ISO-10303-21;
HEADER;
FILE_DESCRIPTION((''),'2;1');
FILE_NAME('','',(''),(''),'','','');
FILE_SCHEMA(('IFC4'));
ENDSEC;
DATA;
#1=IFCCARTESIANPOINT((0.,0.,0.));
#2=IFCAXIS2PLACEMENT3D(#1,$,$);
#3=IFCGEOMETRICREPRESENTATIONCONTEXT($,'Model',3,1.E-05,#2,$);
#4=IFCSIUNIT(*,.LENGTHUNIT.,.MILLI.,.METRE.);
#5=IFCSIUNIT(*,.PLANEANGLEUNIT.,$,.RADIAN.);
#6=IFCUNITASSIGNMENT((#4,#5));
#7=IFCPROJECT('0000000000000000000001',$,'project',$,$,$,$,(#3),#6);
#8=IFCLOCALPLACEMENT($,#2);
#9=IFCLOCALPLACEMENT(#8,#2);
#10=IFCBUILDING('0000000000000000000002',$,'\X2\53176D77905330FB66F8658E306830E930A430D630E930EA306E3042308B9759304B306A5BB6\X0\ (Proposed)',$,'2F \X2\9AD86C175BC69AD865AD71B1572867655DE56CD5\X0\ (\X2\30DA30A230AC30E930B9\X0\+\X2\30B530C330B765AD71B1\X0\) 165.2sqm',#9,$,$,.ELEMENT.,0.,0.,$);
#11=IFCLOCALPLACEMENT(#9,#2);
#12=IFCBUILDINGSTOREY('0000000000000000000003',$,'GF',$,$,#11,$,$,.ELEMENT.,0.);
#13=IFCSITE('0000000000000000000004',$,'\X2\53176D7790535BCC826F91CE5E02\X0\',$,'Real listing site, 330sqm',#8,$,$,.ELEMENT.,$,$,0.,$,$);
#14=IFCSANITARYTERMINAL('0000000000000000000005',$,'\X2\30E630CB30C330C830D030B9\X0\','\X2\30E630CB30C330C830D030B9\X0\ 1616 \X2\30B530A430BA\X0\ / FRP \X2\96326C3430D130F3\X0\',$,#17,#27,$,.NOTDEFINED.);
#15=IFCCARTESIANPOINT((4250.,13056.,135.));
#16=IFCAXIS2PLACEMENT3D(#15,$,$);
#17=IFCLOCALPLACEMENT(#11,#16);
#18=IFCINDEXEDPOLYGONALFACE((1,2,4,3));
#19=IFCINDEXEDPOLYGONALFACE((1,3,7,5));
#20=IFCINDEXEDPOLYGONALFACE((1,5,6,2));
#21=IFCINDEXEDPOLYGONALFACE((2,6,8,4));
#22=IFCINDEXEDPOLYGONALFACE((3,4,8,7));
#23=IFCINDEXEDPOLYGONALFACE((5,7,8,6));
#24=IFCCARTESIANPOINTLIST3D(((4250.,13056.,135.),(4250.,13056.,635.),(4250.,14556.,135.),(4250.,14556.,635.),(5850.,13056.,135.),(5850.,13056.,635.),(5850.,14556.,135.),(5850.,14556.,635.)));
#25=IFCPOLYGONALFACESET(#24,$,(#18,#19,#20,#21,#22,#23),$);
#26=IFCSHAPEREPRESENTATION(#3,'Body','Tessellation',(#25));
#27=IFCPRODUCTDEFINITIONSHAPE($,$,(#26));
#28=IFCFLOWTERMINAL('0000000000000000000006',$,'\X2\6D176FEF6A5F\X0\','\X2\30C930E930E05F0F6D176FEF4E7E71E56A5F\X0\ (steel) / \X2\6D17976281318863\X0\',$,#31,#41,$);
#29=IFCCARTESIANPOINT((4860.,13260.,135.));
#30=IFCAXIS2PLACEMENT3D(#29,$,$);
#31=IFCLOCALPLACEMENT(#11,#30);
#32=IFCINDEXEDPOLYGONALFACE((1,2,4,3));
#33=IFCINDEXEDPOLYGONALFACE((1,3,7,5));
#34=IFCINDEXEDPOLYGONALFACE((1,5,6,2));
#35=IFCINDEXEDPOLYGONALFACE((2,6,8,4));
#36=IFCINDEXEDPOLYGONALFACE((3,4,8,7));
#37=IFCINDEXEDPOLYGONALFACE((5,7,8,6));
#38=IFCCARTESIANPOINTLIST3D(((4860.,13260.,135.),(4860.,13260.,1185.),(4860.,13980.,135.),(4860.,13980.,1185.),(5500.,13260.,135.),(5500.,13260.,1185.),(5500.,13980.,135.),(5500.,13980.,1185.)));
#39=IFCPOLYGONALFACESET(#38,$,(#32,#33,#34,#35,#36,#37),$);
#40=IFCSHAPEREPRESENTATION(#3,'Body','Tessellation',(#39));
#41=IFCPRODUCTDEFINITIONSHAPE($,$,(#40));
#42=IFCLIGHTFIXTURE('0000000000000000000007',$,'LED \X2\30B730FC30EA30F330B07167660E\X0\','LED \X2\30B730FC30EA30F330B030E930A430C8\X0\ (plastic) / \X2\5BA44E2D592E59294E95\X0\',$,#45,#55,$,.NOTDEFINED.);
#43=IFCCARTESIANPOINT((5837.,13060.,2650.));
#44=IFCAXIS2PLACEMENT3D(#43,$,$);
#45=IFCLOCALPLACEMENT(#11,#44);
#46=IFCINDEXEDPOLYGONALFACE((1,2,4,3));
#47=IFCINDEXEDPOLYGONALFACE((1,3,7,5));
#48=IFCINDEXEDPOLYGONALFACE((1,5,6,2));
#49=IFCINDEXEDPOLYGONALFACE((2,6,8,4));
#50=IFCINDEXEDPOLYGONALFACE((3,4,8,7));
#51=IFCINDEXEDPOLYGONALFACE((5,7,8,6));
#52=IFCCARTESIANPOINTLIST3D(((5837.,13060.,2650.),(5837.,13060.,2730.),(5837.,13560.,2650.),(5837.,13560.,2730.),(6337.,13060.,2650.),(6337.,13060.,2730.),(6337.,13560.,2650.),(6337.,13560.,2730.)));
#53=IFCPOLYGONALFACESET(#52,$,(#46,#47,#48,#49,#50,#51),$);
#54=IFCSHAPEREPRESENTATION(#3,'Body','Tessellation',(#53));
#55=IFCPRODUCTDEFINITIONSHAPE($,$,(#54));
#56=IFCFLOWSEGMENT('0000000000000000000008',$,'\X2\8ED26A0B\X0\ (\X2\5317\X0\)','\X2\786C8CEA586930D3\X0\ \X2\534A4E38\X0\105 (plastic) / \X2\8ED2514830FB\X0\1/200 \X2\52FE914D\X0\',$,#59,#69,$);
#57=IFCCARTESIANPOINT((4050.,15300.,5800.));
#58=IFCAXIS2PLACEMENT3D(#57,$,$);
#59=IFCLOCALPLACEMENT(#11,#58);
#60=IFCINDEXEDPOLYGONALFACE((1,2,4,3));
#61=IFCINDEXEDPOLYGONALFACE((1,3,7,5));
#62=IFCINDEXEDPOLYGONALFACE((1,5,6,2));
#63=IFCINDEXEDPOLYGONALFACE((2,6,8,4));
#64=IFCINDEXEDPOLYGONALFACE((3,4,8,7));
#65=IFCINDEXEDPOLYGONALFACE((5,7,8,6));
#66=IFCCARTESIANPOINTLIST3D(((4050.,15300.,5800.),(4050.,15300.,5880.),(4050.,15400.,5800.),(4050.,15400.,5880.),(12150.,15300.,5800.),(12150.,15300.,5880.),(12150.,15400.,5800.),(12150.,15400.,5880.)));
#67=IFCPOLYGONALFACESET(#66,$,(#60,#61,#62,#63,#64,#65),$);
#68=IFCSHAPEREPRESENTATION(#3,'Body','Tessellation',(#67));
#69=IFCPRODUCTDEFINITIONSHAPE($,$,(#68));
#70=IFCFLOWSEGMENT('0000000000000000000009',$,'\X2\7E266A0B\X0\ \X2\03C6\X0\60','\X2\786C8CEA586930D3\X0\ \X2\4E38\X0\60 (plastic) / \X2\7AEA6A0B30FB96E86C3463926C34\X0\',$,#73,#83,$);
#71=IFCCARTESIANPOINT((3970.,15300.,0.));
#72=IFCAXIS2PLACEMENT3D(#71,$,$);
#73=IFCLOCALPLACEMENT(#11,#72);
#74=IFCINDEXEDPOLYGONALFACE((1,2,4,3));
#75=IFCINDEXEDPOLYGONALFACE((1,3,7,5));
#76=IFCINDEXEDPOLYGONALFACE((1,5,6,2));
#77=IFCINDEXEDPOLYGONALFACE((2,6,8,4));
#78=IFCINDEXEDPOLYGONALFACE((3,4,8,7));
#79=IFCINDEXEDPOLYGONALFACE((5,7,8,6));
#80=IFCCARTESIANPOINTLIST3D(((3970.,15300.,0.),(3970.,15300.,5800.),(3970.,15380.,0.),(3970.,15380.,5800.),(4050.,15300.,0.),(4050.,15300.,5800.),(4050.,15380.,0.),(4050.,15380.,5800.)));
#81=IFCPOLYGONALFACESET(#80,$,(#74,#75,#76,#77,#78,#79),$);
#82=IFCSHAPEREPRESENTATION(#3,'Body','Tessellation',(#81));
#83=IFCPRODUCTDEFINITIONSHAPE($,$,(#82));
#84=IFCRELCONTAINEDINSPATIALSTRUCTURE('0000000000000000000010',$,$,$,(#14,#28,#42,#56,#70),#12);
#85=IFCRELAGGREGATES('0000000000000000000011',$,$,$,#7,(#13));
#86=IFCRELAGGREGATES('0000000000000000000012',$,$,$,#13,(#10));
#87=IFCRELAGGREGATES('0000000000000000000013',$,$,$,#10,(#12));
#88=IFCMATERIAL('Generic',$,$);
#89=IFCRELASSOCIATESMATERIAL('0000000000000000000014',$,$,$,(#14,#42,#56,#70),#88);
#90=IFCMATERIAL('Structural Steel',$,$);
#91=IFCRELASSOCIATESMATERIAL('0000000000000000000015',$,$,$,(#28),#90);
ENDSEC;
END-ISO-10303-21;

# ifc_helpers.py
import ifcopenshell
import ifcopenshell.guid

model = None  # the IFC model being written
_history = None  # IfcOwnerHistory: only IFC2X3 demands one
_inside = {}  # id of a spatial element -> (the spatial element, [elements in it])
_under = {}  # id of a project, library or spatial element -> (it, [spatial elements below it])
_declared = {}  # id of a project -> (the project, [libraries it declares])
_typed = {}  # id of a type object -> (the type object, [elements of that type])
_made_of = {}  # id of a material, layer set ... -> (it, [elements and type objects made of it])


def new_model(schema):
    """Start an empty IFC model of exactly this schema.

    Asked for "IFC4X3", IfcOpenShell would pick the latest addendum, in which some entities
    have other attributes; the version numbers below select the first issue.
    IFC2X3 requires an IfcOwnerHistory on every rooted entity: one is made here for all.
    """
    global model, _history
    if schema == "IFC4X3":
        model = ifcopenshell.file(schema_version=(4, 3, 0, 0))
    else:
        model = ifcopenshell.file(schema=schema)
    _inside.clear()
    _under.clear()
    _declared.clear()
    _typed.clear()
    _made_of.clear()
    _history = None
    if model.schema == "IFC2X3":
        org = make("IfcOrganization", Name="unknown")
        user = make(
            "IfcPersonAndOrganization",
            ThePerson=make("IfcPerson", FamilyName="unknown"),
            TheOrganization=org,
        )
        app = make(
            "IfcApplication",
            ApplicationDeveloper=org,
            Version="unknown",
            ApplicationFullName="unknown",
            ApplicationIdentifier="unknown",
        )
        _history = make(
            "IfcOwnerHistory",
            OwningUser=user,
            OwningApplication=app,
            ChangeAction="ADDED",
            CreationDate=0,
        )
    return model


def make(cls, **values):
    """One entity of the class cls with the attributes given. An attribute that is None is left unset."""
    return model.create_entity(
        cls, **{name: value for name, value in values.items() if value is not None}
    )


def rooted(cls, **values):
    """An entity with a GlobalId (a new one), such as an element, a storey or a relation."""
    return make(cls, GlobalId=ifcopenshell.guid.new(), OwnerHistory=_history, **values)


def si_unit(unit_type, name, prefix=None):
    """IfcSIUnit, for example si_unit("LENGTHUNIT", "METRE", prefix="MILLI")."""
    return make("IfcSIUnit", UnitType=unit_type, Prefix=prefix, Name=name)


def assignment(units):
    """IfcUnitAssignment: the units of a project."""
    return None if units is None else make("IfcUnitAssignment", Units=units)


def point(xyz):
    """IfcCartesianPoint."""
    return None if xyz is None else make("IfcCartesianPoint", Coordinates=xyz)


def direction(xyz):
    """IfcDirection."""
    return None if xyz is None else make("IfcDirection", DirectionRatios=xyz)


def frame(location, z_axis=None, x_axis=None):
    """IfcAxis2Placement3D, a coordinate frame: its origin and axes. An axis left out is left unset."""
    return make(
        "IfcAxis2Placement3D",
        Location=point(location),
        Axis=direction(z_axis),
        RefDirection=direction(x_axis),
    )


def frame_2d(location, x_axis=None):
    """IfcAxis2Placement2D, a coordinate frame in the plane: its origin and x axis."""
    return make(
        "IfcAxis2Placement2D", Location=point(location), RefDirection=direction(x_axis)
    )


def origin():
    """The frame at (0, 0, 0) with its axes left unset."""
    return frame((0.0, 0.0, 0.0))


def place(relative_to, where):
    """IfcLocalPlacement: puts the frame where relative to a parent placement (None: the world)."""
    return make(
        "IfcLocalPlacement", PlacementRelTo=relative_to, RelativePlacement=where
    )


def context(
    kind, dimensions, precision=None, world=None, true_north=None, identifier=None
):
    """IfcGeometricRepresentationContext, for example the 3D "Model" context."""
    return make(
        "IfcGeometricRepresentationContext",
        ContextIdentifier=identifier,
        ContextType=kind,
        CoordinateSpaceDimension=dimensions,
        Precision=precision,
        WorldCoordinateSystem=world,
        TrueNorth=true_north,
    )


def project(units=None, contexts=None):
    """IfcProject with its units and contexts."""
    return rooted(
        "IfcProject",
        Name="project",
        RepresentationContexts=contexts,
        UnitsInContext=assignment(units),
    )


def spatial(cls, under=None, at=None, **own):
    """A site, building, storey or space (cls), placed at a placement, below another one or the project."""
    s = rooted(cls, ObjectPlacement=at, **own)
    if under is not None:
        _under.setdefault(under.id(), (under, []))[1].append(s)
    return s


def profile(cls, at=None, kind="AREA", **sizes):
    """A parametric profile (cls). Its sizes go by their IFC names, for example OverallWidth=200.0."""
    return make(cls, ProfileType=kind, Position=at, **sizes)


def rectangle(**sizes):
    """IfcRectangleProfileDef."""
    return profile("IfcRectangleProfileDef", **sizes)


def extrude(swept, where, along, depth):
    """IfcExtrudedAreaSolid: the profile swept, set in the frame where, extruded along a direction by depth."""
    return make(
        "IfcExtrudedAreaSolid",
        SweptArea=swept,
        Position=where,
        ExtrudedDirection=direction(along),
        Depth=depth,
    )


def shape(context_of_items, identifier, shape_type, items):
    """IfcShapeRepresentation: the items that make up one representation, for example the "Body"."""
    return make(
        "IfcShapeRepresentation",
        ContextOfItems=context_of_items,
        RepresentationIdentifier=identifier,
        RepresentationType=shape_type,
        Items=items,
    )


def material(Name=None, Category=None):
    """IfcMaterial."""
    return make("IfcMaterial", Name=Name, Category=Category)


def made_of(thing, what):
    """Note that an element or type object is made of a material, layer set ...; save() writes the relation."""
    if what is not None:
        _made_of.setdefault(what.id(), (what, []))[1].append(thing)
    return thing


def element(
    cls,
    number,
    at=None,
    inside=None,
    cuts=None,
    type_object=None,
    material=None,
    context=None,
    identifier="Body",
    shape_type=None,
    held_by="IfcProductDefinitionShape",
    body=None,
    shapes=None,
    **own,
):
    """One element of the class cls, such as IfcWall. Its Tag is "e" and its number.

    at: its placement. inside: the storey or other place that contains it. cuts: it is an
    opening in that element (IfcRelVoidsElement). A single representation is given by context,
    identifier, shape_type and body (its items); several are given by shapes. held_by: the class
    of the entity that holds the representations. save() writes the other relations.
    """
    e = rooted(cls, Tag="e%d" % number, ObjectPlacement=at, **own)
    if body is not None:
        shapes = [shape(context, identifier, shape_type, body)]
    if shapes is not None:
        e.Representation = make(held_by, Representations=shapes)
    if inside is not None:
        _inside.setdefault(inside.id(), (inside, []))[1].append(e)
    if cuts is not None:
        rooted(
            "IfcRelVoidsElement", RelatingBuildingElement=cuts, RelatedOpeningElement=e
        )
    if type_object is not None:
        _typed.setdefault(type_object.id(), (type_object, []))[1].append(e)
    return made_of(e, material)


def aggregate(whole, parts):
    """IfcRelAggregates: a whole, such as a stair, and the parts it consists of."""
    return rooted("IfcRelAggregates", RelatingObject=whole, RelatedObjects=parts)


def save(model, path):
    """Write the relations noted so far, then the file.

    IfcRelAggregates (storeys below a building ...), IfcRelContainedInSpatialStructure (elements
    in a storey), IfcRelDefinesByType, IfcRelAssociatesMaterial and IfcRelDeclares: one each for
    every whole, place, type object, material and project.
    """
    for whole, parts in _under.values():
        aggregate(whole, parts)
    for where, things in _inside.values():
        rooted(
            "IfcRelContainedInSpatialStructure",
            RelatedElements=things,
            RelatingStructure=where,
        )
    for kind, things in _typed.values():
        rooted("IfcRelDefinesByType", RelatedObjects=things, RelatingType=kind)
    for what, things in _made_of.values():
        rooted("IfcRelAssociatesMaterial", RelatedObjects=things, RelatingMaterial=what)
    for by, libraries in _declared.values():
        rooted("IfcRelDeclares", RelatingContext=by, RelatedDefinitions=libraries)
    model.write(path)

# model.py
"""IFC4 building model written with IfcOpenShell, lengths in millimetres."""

from ifc_helpers import new_model, si_unit, frame, frame_2d, origin, place, context, project, spatial, rectangle, extrude, material, element, save


model = new_model("IFC4")

# Units and contexts
model_context = context("Model", 3, precision=1e-05, world=origin())
ifc_project = project(units=[si_unit("LENGTHUNIT", "METRE", prefix="MILLI"), si_unit("PLANEANGLEUNIT", "RADIAN")], contexts=[model_context])

# Site, building, storey
site_placement = place(None, origin())
site = spatial("IfcSite", under=ifc_project, at=site_placement, Name="北海道富良野市", ObjectType="Real listing site, 330sqm", CompositionType="ELEMENT", RefElevation=0.0)
building_placement = place(site_placement, origin())
building = spatial("IfcBuilding", under=site, at=building_placement, Name="北海道・書斎とライブラリのある静かな家 (Proposed)", ObjectType="2F 高気密高断熱在来工法 (ペアガラス+サッシ断熱) 165.2sqm", CompositionType="ELEMENT", ElevationOfRefHeight=0.0, ElevationOfTerrain=0.0)
storey_placement = place(building_placement, origin())
storey = spatial("IfcBuildingStorey", under=building, at=storey_placement, Name="GF", CompositionType="ELEMENT", Elevation=0.0)

# Sanitary terminal
ifc_material_1 = material(Name="Generic")
sanitary_terminal_placement = place(storey_placement, frame((4250.0, 13056.0, 135.0)))
element("IfcSanitaryTerminal", 1, at=sanitary_terminal_placement, inside=storey, material=ifc_material_1, Name="ユニットバス", Description="ユニットバス 1616 サイズ / FRP 防水パン", PredefinedType="NOTDEFINED", context=model_context, shape_type="SweptSolid", body=[
    extrude(rectangle(XDim=1600.0, YDim=1500.0, at=frame_2d((800.0, 750.0))), frame((4250.0, 13056.0, 135.0)), (0.0, 0.0, 1.0), 500.0),
])

# Flow terminal
ifc_material_2 = material(Name="Structural Steel")
flow_terminal_placement = place(storey_placement, frame((4860.0, 13260.0, 135.0)))
element("IfcFlowTerminal", 2, at=flow_terminal_placement, inside=storey, material=ifc_material_2, Name="洗濯機", Description="ドラム式洗濯乾燥機 (steel) / 洗面脱衣", context=model_context, shape_type="SweptSolid", body=[
    extrude(rectangle(XDim=640.0, YDim=720.0, at=frame_2d((320.0, 360.0))), frame((4860.0, 13260.0, 135.0)), (0.0, 0.0, 1.0), 1050.0),
])

# Light fixture
light_fixture_placement = place(storey_placement, frame((5837.0, 13060.0, 2650.0)))
element("IfcLightFixture", 3, at=light_fixture_placement, inside=storey, material=ifc_material_1, Name="LED シーリング照明", Description="LED シーリングライト (plastic) / 室中央天井", PredefinedType="NOTDEFINED", context=model_context, shape_type="SweptSolid", body=[
    extrude(rectangle(XDim=500.0, YDim=500.0, at=frame_2d((250.0, 250.0))), frame((5837.0, 13060.0, 2650.0)), (0.0, 0.0, 1.0), 80.0),
])

# Flow segments
flow_segment_1_placement = place(storey_placement, frame((4050.0, 15300.0, 5800.0)))
element("IfcFlowSegment", 4, at=flow_segment_1_placement, inside=storey, material=ifc_material_1, Name="軒樋 (北)", Description="硬質塩ビ 半丸105 (plastic) / 軒先・1/200 勾配", context=model_context, shape_type="SweptSolid", body=[
    extrude(rectangle(XDim=8100.0, YDim=100.0, at=frame_2d((4050.0, 50.0))), frame((4050.0, 15300.0, 5800.0)), (0.0, 0.0, 1.0), 80.0),
])
flow_segment_2_placement = place(storey_placement, frame((3970.0, 15300.0, 0.0)))
element("IfcFlowSegment", 5, at=flow_segment_2_placement, inside=storey, material=ifc_material_1, Name="縦樋 φ60", Description="硬質塩ビ 丸60 (plastic) / 竪樋・雨水排水", context=model_context, shape_type="SweptSolid", body=[
    extrude(rectangle(XDim=80.0, YDim=80.0, at=frame_2d((40.0, 40.0))), frame((3970.0, 15300.0, 0.0)), (0.0, 0.0, 1.0), 5800.0),
])

save(model, "model.ifc")
